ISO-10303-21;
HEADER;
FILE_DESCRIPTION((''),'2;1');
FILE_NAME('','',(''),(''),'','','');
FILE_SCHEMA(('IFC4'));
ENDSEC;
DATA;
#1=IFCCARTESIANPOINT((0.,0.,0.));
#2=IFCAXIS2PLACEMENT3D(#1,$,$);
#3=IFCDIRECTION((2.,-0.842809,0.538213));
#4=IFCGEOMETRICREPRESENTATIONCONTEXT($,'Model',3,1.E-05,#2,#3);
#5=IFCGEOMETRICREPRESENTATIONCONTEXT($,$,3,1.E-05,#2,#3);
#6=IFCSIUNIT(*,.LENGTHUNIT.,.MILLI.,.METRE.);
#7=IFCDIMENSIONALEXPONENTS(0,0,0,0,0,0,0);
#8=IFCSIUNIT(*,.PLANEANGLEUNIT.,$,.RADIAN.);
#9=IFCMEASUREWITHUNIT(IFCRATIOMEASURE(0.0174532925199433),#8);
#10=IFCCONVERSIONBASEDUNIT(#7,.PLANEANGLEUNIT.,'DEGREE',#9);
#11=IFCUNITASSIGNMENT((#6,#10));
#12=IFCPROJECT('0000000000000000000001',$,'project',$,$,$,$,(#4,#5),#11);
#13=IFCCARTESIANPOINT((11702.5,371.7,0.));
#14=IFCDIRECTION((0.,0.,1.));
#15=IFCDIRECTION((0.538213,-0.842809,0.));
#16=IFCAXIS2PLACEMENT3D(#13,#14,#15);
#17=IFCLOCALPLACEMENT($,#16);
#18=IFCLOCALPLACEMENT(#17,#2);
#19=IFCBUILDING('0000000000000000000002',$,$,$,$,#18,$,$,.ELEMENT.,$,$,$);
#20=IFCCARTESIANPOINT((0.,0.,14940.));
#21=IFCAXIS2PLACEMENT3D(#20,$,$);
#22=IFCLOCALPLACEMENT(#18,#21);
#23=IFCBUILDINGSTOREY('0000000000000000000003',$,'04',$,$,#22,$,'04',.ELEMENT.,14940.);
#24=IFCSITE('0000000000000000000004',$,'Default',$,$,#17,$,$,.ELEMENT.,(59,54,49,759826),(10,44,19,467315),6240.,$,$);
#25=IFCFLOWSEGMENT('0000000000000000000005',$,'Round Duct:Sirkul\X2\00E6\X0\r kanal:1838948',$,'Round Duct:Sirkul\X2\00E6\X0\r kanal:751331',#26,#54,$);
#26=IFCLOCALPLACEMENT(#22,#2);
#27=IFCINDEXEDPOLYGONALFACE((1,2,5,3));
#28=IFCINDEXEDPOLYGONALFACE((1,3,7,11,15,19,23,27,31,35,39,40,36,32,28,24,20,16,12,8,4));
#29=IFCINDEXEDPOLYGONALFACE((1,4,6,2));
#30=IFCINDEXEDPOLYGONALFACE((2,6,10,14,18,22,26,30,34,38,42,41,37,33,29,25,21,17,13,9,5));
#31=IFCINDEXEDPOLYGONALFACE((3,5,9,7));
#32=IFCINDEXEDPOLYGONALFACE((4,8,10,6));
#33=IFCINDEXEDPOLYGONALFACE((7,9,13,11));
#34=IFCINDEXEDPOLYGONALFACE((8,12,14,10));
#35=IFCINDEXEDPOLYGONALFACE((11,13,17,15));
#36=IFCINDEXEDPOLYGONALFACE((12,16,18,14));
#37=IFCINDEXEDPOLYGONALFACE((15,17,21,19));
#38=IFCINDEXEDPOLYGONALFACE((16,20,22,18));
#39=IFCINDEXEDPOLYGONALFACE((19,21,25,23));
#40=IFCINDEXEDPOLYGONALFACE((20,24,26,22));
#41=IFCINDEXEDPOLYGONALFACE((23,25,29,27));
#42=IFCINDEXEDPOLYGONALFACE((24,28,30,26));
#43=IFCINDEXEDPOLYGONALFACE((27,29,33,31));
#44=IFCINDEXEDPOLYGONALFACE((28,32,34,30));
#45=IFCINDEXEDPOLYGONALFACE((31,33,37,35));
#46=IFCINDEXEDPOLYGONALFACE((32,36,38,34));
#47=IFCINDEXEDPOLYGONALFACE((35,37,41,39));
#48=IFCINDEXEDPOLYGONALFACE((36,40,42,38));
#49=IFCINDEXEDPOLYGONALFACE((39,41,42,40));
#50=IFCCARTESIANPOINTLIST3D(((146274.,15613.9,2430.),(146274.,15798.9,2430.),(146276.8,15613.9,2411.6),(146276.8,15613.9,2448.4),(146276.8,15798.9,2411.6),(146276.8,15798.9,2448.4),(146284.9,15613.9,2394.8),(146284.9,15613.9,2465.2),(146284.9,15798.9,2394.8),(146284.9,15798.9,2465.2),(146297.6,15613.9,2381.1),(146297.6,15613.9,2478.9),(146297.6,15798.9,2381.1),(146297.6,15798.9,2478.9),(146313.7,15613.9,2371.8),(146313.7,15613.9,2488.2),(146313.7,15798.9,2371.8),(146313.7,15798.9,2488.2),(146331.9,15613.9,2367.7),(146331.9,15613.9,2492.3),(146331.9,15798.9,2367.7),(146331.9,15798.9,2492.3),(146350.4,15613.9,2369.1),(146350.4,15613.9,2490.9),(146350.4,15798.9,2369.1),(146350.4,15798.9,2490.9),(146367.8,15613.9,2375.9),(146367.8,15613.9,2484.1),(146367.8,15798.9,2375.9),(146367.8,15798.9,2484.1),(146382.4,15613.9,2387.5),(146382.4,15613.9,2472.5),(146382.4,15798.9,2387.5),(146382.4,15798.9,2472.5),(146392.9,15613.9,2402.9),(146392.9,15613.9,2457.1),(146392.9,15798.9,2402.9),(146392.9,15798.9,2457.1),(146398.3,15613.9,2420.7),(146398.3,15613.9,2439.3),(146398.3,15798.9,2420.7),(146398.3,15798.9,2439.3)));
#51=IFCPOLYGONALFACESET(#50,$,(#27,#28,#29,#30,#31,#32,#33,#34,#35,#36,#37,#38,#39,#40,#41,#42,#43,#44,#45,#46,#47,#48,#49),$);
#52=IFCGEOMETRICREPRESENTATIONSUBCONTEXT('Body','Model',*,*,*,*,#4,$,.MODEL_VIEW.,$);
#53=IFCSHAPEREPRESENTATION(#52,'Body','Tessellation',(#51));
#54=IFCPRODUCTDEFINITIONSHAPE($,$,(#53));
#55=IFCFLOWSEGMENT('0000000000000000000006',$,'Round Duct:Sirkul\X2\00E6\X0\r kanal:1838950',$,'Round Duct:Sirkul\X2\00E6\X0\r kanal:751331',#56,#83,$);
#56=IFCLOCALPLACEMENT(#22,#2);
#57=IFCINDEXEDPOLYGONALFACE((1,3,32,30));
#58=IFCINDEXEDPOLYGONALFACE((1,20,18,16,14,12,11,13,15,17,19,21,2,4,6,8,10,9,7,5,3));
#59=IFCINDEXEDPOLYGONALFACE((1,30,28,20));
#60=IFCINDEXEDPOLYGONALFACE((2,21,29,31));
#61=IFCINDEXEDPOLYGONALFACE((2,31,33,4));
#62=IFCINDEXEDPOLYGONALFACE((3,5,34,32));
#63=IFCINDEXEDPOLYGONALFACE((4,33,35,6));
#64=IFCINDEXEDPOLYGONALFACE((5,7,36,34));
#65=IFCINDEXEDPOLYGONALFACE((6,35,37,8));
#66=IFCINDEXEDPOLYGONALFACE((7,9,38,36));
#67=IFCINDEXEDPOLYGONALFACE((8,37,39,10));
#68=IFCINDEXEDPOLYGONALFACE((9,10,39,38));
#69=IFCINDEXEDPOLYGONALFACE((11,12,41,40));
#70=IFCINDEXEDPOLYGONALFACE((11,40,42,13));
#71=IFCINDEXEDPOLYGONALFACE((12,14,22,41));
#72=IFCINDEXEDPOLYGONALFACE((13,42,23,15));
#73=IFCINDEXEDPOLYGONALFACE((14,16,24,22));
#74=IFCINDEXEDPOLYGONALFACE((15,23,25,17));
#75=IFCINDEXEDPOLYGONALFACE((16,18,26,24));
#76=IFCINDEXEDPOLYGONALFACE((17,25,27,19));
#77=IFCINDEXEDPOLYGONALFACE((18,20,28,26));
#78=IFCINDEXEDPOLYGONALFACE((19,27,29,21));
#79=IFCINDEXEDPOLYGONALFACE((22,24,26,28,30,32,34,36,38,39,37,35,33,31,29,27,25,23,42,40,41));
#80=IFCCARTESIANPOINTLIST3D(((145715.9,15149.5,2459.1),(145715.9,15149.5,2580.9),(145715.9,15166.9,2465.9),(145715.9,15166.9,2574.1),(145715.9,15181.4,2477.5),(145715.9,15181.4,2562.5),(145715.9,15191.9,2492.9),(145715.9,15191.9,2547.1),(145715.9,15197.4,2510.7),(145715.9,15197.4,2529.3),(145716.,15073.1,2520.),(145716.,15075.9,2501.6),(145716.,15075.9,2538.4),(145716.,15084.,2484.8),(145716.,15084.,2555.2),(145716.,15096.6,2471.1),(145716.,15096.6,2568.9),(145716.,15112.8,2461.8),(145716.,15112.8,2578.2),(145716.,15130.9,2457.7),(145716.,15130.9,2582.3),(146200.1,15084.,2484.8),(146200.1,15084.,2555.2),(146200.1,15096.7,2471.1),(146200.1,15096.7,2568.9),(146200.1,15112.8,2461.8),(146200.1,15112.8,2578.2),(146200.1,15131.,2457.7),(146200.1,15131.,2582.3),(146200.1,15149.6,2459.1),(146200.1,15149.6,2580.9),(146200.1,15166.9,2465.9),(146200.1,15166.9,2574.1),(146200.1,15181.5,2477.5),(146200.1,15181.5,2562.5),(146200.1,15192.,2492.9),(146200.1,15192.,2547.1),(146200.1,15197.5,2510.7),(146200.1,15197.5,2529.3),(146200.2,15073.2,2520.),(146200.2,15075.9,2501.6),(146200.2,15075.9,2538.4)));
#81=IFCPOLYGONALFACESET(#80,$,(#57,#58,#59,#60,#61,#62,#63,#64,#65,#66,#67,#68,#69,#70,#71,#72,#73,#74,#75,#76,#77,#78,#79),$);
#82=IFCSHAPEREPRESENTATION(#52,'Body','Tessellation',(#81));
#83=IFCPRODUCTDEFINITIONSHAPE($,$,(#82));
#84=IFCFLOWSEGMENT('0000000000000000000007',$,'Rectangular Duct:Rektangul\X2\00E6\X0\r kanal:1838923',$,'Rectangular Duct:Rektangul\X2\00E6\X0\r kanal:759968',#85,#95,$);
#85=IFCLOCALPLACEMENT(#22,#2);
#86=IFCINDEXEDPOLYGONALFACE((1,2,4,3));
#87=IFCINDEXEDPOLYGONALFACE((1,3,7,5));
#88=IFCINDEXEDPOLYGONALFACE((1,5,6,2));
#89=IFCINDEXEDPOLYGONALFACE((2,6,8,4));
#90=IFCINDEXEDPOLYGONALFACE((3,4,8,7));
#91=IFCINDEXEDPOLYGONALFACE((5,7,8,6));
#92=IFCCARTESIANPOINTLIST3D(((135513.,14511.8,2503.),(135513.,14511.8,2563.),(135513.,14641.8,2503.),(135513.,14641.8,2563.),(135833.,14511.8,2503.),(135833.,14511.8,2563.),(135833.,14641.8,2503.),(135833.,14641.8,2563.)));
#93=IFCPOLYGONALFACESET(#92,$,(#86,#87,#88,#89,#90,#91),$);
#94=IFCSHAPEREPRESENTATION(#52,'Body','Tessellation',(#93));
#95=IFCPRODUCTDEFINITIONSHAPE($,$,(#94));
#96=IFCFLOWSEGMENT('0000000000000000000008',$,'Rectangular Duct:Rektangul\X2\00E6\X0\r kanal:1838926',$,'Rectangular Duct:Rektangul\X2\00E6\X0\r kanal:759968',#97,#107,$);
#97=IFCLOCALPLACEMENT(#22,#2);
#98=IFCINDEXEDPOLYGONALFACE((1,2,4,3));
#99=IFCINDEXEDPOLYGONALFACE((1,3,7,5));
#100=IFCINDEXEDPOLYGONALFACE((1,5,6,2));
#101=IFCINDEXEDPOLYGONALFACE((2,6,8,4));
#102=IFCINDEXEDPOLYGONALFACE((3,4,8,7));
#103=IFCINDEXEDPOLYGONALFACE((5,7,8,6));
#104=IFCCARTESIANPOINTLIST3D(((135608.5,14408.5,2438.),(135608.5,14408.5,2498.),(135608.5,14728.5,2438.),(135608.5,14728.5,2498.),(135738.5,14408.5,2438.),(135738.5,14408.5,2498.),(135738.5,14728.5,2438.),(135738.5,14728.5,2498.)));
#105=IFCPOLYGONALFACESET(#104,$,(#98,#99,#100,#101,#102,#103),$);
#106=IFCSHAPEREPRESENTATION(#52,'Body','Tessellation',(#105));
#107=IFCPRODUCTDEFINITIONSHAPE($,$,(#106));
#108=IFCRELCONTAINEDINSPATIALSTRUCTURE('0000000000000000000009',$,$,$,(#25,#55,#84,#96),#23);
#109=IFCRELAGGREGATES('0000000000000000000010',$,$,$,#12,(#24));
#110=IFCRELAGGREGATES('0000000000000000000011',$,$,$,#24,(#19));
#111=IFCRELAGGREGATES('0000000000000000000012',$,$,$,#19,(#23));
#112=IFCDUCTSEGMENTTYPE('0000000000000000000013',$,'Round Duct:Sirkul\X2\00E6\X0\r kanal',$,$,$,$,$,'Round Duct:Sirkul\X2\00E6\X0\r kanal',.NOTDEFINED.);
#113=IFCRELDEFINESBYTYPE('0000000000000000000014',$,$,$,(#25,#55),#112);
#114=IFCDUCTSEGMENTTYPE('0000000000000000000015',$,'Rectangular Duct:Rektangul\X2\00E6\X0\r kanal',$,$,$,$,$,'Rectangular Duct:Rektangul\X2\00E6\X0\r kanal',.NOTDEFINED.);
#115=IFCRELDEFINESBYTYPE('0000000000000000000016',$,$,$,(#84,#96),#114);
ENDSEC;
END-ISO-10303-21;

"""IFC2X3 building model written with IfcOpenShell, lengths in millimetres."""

from ifc_helpers import new_model, entity, si_unit, converted_unit, direction, frame, frame_2d, origin, origin_2d_with_axis, place, context, subcontext, project, spatial, rectangle, circle, extrude, type_object, element, save


model = new_model("IFC2X3")

# Units and contexts
model_context = context("Model", 3, precision=1e-05, world=origin(), true_north=direction((2.0, -0.842809, 0.538213)))
context_of_model = context(None, 3, precision=1e-05, world=origin(), true_north=direction((2.0, -0.842809, 0.538213)))
body_context = subcontext(model_context, "Body", "Model", "MODEL_VIEW")
ifc_project = project(units=[si_unit("LENGTHUNIT", "METRE", prefix="MILLI"), converted_unit("PLANEANGLEUNIT", "DEGREE", entity("IfcRatioMeasure", 0.0174532925199433), si_unit("PLANEANGLEUNIT", "RADIAN"), dimensions=[0, 0, 0, 0, 0, 0, 0])], contexts=[model_context, context_of_model])

# Site, building, storey
site_placement = place(None, frame((11702.5, 371.7, 0.0), z_axis=(0.0, 0.0, 1.0), x_axis=(0.538213, -0.842809, 0.0)))
site = spatial("IfcSite", under=ifc_project, at=site_placement, Name="Default", CompositionType="ELEMENT", RefLatitude=(59, 54, 49, 759826), RefLongitude=(10, 44, 19, 467315), RefElevation=6240.0)
building_placement = place(site_placement, origin())
building = spatial("IfcBuilding", under=site, at=building_placement, CompositionType="ELEMENT")
storey_placement = place(building_placement, frame((0.0, 0.0, 14940.0)))
storey = spatial("IfcBuildingStorey", under=building, at=storey_placement, Name="04", LongName="04", CompositionType="ELEMENT", Elevation=14940.0)

# Flow segments
duct_segment_type_1 = type_object("IfcDuctSegmentType", Name="Round Duct:Sirkulær kanal", ElementType="Round Duct:Sirkulær kanal", PredefinedType="NOTDEFINED")
flow_segment_1_placement = place(storey_placement, origin())
element("IfcFlowSegment", 1, at=flow_segment_1_placement, inside=storey, type_object=duct_segment_type_1, Name="Round Duct:Sirkulær kanal:1838948", ObjectType="Round Duct:Sirkulær kanal:751331", context=body_context, shape_type="SweptSolid", body=[
    extrude(circle(Radius=62.5, at=frame_2d((0.0, 0.0), x_axis=(1.0, 0.0))), frame((146336.5, 15613.9, 2430.0), z_axis=(0.0, 1.0, 0.0), x_axis=(-1.0, 0.0, 0.0)), (0.0, 0.0, 1.0), 185.0),
])
flow_segment_2_placement = place(storey_placement, origin())
element("IfcFlowSegment", 2, at=flow_segment_2_placement, inside=storey, type_object=duct_segment_type_1, Name="Round Duct:Sirkulær kanal:1838950", ObjectType="Round Duct:Sirkulær kanal:751331", context=body_context, shape_type="SweptSolid", body=[
    extrude(circle(Radius=62.5, at=frame_2d((0.0, 0.0), x_axis=(1.0, 0.0))), frame((145716.0, 15135.6, 2520.0), z_axis=(1.0, 0.000115, 0.0), x_axis=(0.000115, -1.0, 0.0)), (0.0, 0.0, 1.0), 484.2),
])
duct_segment_type_2 = type_object("IfcDuctSegmentType", Name="Rectangular Duct:Rektangulær kanal", ElementType="Rectangular Duct:Rektangulær kanal", PredefinedType="NOTDEFINED")
flow_segment_3_placement = place(storey_placement, origin())
element("IfcFlowSegment", 3, at=flow_segment_3_placement, inside=storey, type_object=duct_segment_type_2, Name="Rectangular Duct:Rektangulær kanal:1838923", ObjectType="Rectangular Duct:Rektangulær kanal:759968", context=body_context, shape_type="SweptSolid", body=[
    extrude(rectangle(XDim=320.0, YDim=130.0, at=origin_2d_with_axis()), frame((135673.0, 14576.8, 2503.0)), (0.0, 0.0, 1.0), 60.0),
])
flow_segment_4_placement = place(storey_placement, origin())
element("IfcFlowSegment", 4, at=flow_segment_4_placement, inside=storey, type_object=duct_segment_type_2, Name="Rectangular Duct:Rektangulær kanal:1838926", ObjectType="Rectangular Duct:Rektangulær kanal:759968", context=body_context, shape_type="SweptSolid", body=[
    extrude(rectangle(XDim=320.0, YDim=130.0, at=frame_2d((0.0, 0.0), x_axis=(1.0, 0.0))), frame((135673.5, 14568.5, 2438.0), z_axis=(0.0, 0.0, 1.0), x_axis=(0.0, 1.0, 0.0)), (0.0, 0.0, 1.0), 60.0),
])

save(model, "model.ifc")
